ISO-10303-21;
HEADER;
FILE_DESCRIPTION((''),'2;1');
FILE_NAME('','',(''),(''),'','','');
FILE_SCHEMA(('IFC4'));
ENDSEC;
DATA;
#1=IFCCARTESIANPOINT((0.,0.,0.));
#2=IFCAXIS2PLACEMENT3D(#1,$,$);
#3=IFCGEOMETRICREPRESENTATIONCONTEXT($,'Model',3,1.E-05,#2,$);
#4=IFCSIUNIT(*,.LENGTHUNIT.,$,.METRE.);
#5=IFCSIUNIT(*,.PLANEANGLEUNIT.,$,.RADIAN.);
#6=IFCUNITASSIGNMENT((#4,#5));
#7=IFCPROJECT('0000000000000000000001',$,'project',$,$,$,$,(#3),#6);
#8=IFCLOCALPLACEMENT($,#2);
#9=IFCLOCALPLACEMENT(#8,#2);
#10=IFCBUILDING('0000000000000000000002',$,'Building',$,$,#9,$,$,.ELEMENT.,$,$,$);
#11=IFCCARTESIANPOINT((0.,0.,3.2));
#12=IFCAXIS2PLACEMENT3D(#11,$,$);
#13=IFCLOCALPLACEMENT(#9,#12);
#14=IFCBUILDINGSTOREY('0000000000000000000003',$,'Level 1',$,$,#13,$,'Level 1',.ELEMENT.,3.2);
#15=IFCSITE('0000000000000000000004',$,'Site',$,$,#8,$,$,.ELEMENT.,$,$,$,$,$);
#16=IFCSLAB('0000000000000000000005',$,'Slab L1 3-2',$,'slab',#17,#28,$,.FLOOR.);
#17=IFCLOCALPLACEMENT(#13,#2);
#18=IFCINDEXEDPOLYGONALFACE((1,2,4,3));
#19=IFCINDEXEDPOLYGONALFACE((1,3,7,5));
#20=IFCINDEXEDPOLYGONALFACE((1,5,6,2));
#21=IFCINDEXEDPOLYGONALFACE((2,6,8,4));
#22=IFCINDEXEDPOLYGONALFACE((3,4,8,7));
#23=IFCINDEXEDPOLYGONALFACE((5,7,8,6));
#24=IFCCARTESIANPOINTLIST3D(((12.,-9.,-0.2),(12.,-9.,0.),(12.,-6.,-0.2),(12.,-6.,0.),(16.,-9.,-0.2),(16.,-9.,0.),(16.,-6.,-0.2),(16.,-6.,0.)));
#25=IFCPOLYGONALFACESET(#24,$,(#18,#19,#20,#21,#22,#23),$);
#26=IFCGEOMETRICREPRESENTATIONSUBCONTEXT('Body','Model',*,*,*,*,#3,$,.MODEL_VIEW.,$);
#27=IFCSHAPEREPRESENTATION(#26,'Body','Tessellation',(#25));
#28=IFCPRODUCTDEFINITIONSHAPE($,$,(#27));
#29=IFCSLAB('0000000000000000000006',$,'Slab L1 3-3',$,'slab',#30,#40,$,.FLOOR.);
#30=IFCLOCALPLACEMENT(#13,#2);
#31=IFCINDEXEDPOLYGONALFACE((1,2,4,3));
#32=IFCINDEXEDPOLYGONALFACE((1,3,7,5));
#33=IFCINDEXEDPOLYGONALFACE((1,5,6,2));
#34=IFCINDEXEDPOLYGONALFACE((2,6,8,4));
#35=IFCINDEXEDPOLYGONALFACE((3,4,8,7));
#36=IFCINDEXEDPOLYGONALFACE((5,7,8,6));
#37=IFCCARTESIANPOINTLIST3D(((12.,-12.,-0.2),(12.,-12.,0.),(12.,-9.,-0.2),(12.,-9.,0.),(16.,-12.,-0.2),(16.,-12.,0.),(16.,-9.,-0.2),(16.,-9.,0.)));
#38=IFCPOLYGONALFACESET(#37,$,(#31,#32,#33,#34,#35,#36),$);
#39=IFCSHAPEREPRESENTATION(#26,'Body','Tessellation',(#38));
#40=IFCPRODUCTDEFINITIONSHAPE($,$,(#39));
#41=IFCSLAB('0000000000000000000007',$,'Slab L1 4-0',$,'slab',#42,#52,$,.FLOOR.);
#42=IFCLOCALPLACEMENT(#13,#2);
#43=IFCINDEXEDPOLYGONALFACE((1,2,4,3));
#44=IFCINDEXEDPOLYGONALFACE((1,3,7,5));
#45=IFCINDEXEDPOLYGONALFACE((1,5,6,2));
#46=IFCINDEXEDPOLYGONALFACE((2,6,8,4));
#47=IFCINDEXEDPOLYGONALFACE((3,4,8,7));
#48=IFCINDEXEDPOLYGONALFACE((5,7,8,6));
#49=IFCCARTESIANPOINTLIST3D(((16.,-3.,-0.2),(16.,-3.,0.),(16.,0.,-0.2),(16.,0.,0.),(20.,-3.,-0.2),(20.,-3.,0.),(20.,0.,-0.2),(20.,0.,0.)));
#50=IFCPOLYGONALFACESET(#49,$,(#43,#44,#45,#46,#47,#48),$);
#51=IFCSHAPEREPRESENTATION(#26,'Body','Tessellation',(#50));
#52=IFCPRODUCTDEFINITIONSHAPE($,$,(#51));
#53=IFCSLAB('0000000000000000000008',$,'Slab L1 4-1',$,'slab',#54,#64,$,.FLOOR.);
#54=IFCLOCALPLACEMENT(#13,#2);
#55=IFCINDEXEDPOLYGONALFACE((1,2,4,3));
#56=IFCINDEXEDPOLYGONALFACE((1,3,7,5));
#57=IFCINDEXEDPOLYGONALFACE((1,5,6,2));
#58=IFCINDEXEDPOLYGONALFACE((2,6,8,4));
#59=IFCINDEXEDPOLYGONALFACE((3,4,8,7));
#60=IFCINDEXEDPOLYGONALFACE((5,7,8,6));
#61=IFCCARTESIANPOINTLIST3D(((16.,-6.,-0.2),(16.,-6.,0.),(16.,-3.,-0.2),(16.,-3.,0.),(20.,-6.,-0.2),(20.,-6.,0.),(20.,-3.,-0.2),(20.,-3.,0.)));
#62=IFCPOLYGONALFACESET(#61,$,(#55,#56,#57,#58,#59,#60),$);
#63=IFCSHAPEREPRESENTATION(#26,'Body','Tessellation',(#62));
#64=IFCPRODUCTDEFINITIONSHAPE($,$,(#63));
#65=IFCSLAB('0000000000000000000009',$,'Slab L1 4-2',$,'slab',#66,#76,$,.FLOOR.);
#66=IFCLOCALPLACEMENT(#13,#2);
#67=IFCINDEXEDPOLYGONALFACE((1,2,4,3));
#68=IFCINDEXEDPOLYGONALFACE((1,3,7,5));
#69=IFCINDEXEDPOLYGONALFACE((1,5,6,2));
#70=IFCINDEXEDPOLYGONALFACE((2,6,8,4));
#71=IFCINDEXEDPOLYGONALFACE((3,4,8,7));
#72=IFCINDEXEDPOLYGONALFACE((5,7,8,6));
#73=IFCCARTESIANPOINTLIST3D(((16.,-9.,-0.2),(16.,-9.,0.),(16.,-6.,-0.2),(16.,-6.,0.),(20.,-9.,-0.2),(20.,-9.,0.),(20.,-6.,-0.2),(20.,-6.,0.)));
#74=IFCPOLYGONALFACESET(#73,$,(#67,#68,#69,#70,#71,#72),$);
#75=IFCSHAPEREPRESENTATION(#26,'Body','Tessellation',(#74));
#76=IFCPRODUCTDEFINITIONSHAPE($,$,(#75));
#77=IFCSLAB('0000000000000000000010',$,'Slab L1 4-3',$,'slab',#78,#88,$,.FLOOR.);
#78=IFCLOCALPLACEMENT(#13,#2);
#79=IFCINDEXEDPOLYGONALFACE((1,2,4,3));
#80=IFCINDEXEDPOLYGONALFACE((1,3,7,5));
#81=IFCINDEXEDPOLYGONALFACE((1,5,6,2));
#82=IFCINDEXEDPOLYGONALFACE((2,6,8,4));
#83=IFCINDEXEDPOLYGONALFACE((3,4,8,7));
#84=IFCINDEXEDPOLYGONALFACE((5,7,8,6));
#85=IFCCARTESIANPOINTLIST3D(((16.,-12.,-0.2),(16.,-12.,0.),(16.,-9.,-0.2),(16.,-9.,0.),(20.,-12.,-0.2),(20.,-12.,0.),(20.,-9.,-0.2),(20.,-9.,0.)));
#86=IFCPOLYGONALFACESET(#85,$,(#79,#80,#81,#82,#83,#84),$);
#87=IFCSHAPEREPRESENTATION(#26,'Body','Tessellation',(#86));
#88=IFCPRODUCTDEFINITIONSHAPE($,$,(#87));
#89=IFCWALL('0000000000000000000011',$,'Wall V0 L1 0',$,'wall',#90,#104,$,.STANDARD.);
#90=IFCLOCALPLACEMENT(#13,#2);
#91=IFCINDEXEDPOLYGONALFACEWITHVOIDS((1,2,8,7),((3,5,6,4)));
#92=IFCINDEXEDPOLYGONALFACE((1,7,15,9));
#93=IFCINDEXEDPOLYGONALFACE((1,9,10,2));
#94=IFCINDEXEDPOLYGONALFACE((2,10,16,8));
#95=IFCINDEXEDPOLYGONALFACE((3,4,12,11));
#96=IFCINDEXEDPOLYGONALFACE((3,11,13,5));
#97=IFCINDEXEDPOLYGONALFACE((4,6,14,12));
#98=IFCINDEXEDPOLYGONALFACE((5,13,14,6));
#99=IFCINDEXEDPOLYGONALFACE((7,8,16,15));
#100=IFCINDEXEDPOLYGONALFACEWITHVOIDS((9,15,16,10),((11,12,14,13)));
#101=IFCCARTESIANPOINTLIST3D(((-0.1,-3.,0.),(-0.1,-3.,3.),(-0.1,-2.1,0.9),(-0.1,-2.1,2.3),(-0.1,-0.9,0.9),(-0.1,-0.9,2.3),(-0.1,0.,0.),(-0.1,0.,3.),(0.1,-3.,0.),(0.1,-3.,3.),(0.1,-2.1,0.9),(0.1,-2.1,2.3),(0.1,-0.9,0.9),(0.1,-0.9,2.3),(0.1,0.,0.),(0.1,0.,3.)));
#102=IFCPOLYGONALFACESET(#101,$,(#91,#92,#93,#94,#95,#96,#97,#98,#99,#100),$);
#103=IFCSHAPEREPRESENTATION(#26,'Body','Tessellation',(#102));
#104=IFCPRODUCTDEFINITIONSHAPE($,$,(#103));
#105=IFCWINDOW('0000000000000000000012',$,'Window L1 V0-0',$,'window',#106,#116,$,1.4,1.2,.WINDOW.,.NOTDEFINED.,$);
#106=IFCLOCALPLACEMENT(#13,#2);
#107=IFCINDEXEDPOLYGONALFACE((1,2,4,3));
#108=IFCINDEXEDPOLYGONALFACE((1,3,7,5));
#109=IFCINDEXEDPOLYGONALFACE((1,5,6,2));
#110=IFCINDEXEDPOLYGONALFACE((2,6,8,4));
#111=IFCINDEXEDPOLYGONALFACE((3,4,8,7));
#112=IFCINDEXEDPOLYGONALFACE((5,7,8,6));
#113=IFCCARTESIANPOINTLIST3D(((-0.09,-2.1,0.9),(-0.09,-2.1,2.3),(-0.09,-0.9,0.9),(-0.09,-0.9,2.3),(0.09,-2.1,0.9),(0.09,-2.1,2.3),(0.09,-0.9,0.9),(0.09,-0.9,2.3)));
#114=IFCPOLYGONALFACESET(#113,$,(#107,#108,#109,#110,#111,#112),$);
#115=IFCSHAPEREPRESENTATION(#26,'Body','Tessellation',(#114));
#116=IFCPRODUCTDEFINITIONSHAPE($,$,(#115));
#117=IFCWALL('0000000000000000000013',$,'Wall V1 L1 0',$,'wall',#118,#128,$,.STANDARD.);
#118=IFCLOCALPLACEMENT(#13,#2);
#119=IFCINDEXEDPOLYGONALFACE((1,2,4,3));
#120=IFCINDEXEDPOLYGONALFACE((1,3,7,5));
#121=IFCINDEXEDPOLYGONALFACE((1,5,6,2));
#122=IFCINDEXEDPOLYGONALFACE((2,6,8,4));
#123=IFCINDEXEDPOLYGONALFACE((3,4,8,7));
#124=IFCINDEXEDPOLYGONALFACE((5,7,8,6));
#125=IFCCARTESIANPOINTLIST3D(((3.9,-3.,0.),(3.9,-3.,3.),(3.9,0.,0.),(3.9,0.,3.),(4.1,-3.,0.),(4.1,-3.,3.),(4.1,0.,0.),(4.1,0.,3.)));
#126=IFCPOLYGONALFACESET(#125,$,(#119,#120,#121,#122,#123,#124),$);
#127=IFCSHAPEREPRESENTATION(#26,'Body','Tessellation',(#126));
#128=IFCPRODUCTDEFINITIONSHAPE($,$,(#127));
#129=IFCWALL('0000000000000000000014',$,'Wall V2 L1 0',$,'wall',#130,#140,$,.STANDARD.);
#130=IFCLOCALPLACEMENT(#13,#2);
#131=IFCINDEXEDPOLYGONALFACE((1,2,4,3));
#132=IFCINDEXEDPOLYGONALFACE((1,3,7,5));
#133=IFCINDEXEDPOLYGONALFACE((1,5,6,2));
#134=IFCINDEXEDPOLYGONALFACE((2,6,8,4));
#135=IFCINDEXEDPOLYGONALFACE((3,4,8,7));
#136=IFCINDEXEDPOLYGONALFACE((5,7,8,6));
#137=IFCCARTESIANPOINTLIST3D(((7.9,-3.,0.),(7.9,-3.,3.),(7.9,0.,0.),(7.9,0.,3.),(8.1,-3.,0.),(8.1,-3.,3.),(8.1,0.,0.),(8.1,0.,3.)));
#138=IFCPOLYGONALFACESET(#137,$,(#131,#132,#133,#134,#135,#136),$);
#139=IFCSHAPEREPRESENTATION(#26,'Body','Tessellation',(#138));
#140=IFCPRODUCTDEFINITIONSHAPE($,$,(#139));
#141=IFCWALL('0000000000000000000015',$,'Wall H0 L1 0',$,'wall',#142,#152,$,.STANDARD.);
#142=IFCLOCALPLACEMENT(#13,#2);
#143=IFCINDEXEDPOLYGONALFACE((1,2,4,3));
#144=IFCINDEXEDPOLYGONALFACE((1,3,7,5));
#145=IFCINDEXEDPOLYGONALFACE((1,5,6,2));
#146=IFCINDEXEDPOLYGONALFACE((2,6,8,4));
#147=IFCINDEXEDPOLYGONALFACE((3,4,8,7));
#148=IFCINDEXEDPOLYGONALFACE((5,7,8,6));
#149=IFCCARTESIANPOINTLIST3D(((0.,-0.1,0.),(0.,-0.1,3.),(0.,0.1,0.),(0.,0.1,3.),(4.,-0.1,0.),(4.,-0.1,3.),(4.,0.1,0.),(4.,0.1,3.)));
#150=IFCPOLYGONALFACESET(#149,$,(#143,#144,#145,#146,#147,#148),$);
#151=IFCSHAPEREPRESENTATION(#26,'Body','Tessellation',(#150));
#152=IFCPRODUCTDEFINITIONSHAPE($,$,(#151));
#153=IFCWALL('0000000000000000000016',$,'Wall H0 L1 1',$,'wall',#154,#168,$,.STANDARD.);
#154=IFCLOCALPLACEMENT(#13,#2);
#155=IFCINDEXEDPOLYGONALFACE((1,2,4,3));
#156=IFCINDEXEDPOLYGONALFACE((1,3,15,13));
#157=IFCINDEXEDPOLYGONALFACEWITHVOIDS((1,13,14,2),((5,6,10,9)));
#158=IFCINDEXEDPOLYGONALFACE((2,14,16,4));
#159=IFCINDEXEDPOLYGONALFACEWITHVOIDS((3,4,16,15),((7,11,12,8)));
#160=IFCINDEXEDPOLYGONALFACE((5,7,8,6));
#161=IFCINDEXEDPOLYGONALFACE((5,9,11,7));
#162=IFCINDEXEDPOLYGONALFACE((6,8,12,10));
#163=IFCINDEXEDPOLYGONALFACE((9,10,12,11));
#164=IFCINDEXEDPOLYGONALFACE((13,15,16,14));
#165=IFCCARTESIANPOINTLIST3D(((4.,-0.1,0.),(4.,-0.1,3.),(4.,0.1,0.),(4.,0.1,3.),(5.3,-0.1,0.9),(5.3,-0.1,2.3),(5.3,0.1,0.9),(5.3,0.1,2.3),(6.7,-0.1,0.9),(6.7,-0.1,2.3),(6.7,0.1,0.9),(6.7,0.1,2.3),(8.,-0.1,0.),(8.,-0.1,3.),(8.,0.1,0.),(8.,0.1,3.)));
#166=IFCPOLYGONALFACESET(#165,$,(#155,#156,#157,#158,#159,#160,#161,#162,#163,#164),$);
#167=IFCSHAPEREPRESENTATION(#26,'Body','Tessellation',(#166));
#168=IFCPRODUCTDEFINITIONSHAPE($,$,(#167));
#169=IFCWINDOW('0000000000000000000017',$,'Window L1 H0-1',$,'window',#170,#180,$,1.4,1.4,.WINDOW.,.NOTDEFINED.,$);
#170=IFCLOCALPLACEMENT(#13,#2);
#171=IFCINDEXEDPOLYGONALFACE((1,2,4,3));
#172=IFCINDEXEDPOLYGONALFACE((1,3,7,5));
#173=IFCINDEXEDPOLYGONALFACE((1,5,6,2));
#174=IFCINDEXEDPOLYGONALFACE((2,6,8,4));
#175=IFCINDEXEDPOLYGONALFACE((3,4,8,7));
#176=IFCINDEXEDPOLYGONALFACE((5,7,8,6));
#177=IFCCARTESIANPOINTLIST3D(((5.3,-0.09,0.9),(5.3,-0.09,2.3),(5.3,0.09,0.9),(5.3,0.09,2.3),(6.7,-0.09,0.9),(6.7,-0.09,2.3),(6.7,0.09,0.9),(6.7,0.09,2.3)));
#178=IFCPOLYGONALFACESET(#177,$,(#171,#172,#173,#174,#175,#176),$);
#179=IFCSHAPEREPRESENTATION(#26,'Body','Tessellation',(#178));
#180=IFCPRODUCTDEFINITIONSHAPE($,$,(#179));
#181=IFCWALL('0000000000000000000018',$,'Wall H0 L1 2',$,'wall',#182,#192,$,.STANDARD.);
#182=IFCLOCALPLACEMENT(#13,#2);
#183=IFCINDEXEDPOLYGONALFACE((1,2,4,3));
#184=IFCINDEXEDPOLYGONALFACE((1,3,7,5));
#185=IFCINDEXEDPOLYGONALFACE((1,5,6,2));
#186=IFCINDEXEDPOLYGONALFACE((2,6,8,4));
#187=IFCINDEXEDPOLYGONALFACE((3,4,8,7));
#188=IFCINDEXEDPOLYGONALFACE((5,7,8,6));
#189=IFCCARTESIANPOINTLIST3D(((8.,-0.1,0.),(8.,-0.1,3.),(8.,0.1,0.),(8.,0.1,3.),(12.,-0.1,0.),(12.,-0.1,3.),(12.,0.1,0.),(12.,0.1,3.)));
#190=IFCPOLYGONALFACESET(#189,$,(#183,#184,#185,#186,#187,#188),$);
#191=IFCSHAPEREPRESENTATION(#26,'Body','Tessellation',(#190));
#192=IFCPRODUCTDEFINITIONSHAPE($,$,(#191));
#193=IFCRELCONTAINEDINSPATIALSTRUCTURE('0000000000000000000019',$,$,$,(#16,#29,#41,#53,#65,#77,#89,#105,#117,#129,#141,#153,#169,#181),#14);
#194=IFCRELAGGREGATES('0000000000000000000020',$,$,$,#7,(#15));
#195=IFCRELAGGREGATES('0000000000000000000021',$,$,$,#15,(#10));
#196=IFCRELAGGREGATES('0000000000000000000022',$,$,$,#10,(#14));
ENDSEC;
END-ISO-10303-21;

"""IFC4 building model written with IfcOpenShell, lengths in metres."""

from ifc_helpers import new_model, si_unit, frame, frame_2d, origin, origin_with_axes, origin_2d, place, context, subcontext, project, spatial, polyline, rectangle, outline, extrude, element, fill, save


model = new_model("IFC4")

# Units and contexts
model_context = context("Model", 3, precision=1e-05, world=origin())
body_context = subcontext(model_context, "Body", "Model", "MODEL_VIEW")
ifc_project = project(units=[si_unit("LENGTHUNIT", "METRE"), si_unit("PLANEANGLEUNIT", "RADIAN")], contexts=[model_context])

# Site, building, storey
site_placement = place(None, origin())
site = spatial("IfcSite", under=ifc_project, at=site_placement, Name="Site", CompositionType="ELEMENT")
building_placement = place(site_placement, origin())
building = spatial("IfcBuilding", under=site, at=building_placement, Name="Building", CompositionType="ELEMENT")
storey_placement = place(building_placement, frame((0.0, 0.0, 3.2)))
storey = spatial("IfcBuildingStorey", under=building, at=storey_placement, Name="Level 1", LongName="Level 1", CompositionType="ELEMENT", Elevation=3.2)

# Slabs
slab_1_placement = place(storey_placement, frame((0.0, 0.0, -0.2)))
element("IfcSlab", 1, at=slab_1_placement, inside=storey, Name="Slab L1 3-2", ObjectType="slab", PredefinedType="FLOOR", context=body_context, shape_type="SweptSolid", body=[
    extrude(outline(polyline([(12.0, -9.0), (16.0, -9.0), (16.0, -6.0), (12.0, -6.0), (12.0, -9.0)])), origin(), (0.0, 0.0, 1.0), 0.2),
])
slab_2_placement = place(storey_placement, frame((0.0, 0.0, -0.2)))
element("IfcSlab", 2, at=slab_2_placement, inside=storey, Name="Slab L1 3-3", ObjectType="slab", PredefinedType="FLOOR", context=body_context, shape_type="SweptSolid", body=[
    extrude(outline(polyline([(12.0, -12.0), (16.0, -12.0), (16.0, -9.0), (12.0, -9.0), (12.0, -12.0)])), origin(), (0.0, 0.0, 1.0), 0.2),
])
slab_3_placement = place(storey_placement, frame((0.0, 0.0, -0.2)))
element("IfcSlab", 3, at=slab_3_placement, inside=storey, Name="Slab L1 4-0", ObjectType="slab", PredefinedType="FLOOR", context=body_context, shape_type="SweptSolid", body=[
    extrude(outline(polyline([(16.0, -3.0), (20.0, -3.0), (20.0, 0.0), (16.0, 0.0), (16.0, -3.0)])), origin(), (0.0, 0.0, 1.0), 0.2),
])
slab_4_placement = place(storey_placement, frame((0.0, 0.0, -0.2)))
element("IfcSlab", 4, at=slab_4_placement, inside=storey, Name="Slab L1 4-1", ObjectType="slab", PredefinedType="FLOOR", context=body_context, shape_type="SweptSolid", body=[
    extrude(outline(polyline([(16.0, -6.0), (20.0, -6.0), (20.0, -3.0), (16.0, -3.0), (16.0, -6.0)])), origin(), (0.0, 0.0, 1.0), 0.2),
])
slab_5_placement = place(storey_placement, frame((0.0, 0.0, -0.2)))
element("IfcSlab", 5, at=slab_5_placement, inside=storey, Name="Slab L1 4-2", ObjectType="slab", PredefinedType="FLOOR", context=body_context, shape_type="SweptSolid", body=[
    extrude(outline(polyline([(16.0, -9.0), (20.0, -9.0), (20.0, -6.0), (16.0, -6.0), (16.0, -9.0)])), origin(), (0.0, 0.0, 1.0), 0.2),
])
slab_6_placement = place(storey_placement, frame((0.0, 0.0, -0.2)))
element("IfcSlab", 6, at=slab_6_placement, inside=storey, Name="Slab L1 4-3", ObjectType="slab", PredefinedType="FLOOR", context=body_context, shape_type="SweptSolid", body=[
    extrude(outline(polyline([(16.0, -12.0), (20.0, -12.0), (20.0, -9.0), (16.0, -9.0), (16.0, -12.0)])), origin(), (0.0, 0.0, 1.0), 0.2),
])

# Wall, opening, window
wall_1_placement = place(storey_placement, frame((0.0, 0.0, 0.0), z_axis=(0.0, 0.0, 1.0), x_axis=(0.0, -1.0, 0.0)))
wall_1 = element("IfcWall", 7, at=wall_1_placement, inside=storey, Name="Wall V0 L1 0", ObjectType="wall", PredefinedType="STANDARD", context=body_context, shape_type="SweptSolid", body=[
    extrude(rectangle(XDim=3.0, YDim=0.2, at=frame_2d((1.5, 0.0))), origin(), (0.0, 0.0, 1.0), 3.0),
])
opening_1_placement = place(storey_placement, frame((0.0, -1.5, 0.9), z_axis=(0.0, 0.0, 1.0), x_axis=(0.0, -1.0, 0.0)))
opening_1 = element("IfcOpeningElement", 8, at=opening_1_placement, cuts=wall_1, ObjectType="Opening", PredefinedType="OPENING", context=body_context, shape_type="SweptSolid", body=[
    extrude(rectangle(XDim=1.2, YDim=0.22, at=origin_2d()), origin(), (0.0, 0.0, 1.0), 1.4),
])
window_1_placement = place(storey_placement, frame((0.0, -1.5, 0.9), z_axis=(0.0, 0.0, 1.0), x_axis=(0.0, -1.0, 0.0)))
window_1 = element("IfcWindow", 9, at=window_1_placement, inside=storey, Name="Window L1 V0-0", ObjectType="window", OverallHeight=1.4, OverallWidth=1.2, PartitioningType="NOTDEFINED", PredefinedType="WINDOW", context=body_context, shape_type="SweptSolid", body=[
    extrude(rectangle(XDim=1.2, YDim=0.18, at=origin_2d()), origin(), (0.0, 0.0, 1.0), 1.4),
])
fill(opening_1, window_1)

# Walls
for number, where, z_axis, x_axis, name in (
    (10, (4.0, 0.0, 0.0), (0.0, 0.0, 1.0), (0.0, -1.0, 0.0), "Wall V1 L1 0"),
    (11, (8.0, 0.0, 0.0), (0.0, 0.0, 1.0), (0.0, -1.0, 0.0), "Wall V2 L1 0"),
):
    element("IfcWall", number, at=place(storey_placement, frame(where, z_axis=z_axis, x_axis=x_axis)), inside=storey, Name=name, ObjectType="wall", PredefinedType="STANDARD", context=body_context, shape_type="SweptSolid", body=[
        extrude(rectangle(XDim=3.0, YDim=0.2, at=frame_2d((1.5, 0.0))), origin(), (0.0, 0.0, 1.0), 3.0),
    ])
wall_2_placement = place(storey_placement, origin_with_axes())
element("IfcWall", 12, at=wall_2_placement, inside=storey, Name="Wall H0 L1 0", ObjectType="wall", PredefinedType="STANDARD", context=body_context, shape_type="SweptSolid", body=[
    extrude(rectangle(XDim=4.0, YDim=0.2, at=frame_2d((2.0, 0.0))), origin(), (0.0, 0.0, 1.0), 3.0),
])

# Wall, opening, window
wall_3_placement = place(storey_placement, frame((4.0, 0.0, 0.0), z_axis=(0.0, 0.0, 1.0), x_axis=(1.0, 0.0, 0.0)))
wall_3 = element("IfcWall", 13, at=wall_3_placement, inside=storey, Name="Wall H0 L1 1", ObjectType="wall", PredefinedType="STANDARD", context=body_context, shape_type="SweptSolid", body=[
    extrude(rectangle(XDim=4.0, YDim=0.2, at=frame_2d((2.0, 0.0))), origin(), (0.0, 0.0, 1.0), 3.0),
])
opening_2_placement = place(storey_placement, frame((6.0, 0.0, 0.9), z_axis=(0.0, 0.0, 1.0), x_axis=(1.0, 0.0, 0.0)))
opening_2 = element("IfcOpeningElement", 14, at=opening_2_placement, cuts=wall_3, ObjectType="Opening", PredefinedType="OPENING", context=body_context, shape_type="SweptSolid", body=[
    extrude(rectangle(XDim=1.4, YDim=0.22, at=origin_2d()), origin(), (0.0, 0.0, 1.0), 1.4),
])
window_2_placement = place(storey_placement, frame((6.0, 0.0, 0.9), z_axis=(0.0, 0.0, 1.0), x_axis=(1.0, 0.0, 0.0)))
window_2 = element("IfcWindow", 15, at=window_2_placement, inside=storey, Name="Window L1 H0-1", ObjectType="window", OverallHeight=1.4, OverallWidth=1.4, PartitioningType="NOTDEFINED", PredefinedType="WINDOW", context=body_context, shape_type="SweptSolid", body=[
    extrude(rectangle(XDim=1.4, YDim=0.18, at=origin_2d()), origin(), (0.0, 0.0, 1.0), 1.4),
])
fill(opening_2, window_2)

# Wall
wall_4_placement = place(storey_placement, frame((8.0, 0.0, 0.0), z_axis=(0.0, 0.0, 1.0), x_axis=(1.0, 0.0, 0.0)))
element("IfcWall", 16, at=wall_4_placement, inside=storey, Name="Wall H0 L1 2", ObjectType="wall", PredefinedType="STANDARD", context=body_context, shape_type="SweptSolid", body=[
    extrude(rectangle(XDim=4.0, YDim=0.2, at=frame_2d((2.0, 0.0))), origin(), (0.0, 0.0, 1.0), 3.0),
])

save(model, "model.ifc")
